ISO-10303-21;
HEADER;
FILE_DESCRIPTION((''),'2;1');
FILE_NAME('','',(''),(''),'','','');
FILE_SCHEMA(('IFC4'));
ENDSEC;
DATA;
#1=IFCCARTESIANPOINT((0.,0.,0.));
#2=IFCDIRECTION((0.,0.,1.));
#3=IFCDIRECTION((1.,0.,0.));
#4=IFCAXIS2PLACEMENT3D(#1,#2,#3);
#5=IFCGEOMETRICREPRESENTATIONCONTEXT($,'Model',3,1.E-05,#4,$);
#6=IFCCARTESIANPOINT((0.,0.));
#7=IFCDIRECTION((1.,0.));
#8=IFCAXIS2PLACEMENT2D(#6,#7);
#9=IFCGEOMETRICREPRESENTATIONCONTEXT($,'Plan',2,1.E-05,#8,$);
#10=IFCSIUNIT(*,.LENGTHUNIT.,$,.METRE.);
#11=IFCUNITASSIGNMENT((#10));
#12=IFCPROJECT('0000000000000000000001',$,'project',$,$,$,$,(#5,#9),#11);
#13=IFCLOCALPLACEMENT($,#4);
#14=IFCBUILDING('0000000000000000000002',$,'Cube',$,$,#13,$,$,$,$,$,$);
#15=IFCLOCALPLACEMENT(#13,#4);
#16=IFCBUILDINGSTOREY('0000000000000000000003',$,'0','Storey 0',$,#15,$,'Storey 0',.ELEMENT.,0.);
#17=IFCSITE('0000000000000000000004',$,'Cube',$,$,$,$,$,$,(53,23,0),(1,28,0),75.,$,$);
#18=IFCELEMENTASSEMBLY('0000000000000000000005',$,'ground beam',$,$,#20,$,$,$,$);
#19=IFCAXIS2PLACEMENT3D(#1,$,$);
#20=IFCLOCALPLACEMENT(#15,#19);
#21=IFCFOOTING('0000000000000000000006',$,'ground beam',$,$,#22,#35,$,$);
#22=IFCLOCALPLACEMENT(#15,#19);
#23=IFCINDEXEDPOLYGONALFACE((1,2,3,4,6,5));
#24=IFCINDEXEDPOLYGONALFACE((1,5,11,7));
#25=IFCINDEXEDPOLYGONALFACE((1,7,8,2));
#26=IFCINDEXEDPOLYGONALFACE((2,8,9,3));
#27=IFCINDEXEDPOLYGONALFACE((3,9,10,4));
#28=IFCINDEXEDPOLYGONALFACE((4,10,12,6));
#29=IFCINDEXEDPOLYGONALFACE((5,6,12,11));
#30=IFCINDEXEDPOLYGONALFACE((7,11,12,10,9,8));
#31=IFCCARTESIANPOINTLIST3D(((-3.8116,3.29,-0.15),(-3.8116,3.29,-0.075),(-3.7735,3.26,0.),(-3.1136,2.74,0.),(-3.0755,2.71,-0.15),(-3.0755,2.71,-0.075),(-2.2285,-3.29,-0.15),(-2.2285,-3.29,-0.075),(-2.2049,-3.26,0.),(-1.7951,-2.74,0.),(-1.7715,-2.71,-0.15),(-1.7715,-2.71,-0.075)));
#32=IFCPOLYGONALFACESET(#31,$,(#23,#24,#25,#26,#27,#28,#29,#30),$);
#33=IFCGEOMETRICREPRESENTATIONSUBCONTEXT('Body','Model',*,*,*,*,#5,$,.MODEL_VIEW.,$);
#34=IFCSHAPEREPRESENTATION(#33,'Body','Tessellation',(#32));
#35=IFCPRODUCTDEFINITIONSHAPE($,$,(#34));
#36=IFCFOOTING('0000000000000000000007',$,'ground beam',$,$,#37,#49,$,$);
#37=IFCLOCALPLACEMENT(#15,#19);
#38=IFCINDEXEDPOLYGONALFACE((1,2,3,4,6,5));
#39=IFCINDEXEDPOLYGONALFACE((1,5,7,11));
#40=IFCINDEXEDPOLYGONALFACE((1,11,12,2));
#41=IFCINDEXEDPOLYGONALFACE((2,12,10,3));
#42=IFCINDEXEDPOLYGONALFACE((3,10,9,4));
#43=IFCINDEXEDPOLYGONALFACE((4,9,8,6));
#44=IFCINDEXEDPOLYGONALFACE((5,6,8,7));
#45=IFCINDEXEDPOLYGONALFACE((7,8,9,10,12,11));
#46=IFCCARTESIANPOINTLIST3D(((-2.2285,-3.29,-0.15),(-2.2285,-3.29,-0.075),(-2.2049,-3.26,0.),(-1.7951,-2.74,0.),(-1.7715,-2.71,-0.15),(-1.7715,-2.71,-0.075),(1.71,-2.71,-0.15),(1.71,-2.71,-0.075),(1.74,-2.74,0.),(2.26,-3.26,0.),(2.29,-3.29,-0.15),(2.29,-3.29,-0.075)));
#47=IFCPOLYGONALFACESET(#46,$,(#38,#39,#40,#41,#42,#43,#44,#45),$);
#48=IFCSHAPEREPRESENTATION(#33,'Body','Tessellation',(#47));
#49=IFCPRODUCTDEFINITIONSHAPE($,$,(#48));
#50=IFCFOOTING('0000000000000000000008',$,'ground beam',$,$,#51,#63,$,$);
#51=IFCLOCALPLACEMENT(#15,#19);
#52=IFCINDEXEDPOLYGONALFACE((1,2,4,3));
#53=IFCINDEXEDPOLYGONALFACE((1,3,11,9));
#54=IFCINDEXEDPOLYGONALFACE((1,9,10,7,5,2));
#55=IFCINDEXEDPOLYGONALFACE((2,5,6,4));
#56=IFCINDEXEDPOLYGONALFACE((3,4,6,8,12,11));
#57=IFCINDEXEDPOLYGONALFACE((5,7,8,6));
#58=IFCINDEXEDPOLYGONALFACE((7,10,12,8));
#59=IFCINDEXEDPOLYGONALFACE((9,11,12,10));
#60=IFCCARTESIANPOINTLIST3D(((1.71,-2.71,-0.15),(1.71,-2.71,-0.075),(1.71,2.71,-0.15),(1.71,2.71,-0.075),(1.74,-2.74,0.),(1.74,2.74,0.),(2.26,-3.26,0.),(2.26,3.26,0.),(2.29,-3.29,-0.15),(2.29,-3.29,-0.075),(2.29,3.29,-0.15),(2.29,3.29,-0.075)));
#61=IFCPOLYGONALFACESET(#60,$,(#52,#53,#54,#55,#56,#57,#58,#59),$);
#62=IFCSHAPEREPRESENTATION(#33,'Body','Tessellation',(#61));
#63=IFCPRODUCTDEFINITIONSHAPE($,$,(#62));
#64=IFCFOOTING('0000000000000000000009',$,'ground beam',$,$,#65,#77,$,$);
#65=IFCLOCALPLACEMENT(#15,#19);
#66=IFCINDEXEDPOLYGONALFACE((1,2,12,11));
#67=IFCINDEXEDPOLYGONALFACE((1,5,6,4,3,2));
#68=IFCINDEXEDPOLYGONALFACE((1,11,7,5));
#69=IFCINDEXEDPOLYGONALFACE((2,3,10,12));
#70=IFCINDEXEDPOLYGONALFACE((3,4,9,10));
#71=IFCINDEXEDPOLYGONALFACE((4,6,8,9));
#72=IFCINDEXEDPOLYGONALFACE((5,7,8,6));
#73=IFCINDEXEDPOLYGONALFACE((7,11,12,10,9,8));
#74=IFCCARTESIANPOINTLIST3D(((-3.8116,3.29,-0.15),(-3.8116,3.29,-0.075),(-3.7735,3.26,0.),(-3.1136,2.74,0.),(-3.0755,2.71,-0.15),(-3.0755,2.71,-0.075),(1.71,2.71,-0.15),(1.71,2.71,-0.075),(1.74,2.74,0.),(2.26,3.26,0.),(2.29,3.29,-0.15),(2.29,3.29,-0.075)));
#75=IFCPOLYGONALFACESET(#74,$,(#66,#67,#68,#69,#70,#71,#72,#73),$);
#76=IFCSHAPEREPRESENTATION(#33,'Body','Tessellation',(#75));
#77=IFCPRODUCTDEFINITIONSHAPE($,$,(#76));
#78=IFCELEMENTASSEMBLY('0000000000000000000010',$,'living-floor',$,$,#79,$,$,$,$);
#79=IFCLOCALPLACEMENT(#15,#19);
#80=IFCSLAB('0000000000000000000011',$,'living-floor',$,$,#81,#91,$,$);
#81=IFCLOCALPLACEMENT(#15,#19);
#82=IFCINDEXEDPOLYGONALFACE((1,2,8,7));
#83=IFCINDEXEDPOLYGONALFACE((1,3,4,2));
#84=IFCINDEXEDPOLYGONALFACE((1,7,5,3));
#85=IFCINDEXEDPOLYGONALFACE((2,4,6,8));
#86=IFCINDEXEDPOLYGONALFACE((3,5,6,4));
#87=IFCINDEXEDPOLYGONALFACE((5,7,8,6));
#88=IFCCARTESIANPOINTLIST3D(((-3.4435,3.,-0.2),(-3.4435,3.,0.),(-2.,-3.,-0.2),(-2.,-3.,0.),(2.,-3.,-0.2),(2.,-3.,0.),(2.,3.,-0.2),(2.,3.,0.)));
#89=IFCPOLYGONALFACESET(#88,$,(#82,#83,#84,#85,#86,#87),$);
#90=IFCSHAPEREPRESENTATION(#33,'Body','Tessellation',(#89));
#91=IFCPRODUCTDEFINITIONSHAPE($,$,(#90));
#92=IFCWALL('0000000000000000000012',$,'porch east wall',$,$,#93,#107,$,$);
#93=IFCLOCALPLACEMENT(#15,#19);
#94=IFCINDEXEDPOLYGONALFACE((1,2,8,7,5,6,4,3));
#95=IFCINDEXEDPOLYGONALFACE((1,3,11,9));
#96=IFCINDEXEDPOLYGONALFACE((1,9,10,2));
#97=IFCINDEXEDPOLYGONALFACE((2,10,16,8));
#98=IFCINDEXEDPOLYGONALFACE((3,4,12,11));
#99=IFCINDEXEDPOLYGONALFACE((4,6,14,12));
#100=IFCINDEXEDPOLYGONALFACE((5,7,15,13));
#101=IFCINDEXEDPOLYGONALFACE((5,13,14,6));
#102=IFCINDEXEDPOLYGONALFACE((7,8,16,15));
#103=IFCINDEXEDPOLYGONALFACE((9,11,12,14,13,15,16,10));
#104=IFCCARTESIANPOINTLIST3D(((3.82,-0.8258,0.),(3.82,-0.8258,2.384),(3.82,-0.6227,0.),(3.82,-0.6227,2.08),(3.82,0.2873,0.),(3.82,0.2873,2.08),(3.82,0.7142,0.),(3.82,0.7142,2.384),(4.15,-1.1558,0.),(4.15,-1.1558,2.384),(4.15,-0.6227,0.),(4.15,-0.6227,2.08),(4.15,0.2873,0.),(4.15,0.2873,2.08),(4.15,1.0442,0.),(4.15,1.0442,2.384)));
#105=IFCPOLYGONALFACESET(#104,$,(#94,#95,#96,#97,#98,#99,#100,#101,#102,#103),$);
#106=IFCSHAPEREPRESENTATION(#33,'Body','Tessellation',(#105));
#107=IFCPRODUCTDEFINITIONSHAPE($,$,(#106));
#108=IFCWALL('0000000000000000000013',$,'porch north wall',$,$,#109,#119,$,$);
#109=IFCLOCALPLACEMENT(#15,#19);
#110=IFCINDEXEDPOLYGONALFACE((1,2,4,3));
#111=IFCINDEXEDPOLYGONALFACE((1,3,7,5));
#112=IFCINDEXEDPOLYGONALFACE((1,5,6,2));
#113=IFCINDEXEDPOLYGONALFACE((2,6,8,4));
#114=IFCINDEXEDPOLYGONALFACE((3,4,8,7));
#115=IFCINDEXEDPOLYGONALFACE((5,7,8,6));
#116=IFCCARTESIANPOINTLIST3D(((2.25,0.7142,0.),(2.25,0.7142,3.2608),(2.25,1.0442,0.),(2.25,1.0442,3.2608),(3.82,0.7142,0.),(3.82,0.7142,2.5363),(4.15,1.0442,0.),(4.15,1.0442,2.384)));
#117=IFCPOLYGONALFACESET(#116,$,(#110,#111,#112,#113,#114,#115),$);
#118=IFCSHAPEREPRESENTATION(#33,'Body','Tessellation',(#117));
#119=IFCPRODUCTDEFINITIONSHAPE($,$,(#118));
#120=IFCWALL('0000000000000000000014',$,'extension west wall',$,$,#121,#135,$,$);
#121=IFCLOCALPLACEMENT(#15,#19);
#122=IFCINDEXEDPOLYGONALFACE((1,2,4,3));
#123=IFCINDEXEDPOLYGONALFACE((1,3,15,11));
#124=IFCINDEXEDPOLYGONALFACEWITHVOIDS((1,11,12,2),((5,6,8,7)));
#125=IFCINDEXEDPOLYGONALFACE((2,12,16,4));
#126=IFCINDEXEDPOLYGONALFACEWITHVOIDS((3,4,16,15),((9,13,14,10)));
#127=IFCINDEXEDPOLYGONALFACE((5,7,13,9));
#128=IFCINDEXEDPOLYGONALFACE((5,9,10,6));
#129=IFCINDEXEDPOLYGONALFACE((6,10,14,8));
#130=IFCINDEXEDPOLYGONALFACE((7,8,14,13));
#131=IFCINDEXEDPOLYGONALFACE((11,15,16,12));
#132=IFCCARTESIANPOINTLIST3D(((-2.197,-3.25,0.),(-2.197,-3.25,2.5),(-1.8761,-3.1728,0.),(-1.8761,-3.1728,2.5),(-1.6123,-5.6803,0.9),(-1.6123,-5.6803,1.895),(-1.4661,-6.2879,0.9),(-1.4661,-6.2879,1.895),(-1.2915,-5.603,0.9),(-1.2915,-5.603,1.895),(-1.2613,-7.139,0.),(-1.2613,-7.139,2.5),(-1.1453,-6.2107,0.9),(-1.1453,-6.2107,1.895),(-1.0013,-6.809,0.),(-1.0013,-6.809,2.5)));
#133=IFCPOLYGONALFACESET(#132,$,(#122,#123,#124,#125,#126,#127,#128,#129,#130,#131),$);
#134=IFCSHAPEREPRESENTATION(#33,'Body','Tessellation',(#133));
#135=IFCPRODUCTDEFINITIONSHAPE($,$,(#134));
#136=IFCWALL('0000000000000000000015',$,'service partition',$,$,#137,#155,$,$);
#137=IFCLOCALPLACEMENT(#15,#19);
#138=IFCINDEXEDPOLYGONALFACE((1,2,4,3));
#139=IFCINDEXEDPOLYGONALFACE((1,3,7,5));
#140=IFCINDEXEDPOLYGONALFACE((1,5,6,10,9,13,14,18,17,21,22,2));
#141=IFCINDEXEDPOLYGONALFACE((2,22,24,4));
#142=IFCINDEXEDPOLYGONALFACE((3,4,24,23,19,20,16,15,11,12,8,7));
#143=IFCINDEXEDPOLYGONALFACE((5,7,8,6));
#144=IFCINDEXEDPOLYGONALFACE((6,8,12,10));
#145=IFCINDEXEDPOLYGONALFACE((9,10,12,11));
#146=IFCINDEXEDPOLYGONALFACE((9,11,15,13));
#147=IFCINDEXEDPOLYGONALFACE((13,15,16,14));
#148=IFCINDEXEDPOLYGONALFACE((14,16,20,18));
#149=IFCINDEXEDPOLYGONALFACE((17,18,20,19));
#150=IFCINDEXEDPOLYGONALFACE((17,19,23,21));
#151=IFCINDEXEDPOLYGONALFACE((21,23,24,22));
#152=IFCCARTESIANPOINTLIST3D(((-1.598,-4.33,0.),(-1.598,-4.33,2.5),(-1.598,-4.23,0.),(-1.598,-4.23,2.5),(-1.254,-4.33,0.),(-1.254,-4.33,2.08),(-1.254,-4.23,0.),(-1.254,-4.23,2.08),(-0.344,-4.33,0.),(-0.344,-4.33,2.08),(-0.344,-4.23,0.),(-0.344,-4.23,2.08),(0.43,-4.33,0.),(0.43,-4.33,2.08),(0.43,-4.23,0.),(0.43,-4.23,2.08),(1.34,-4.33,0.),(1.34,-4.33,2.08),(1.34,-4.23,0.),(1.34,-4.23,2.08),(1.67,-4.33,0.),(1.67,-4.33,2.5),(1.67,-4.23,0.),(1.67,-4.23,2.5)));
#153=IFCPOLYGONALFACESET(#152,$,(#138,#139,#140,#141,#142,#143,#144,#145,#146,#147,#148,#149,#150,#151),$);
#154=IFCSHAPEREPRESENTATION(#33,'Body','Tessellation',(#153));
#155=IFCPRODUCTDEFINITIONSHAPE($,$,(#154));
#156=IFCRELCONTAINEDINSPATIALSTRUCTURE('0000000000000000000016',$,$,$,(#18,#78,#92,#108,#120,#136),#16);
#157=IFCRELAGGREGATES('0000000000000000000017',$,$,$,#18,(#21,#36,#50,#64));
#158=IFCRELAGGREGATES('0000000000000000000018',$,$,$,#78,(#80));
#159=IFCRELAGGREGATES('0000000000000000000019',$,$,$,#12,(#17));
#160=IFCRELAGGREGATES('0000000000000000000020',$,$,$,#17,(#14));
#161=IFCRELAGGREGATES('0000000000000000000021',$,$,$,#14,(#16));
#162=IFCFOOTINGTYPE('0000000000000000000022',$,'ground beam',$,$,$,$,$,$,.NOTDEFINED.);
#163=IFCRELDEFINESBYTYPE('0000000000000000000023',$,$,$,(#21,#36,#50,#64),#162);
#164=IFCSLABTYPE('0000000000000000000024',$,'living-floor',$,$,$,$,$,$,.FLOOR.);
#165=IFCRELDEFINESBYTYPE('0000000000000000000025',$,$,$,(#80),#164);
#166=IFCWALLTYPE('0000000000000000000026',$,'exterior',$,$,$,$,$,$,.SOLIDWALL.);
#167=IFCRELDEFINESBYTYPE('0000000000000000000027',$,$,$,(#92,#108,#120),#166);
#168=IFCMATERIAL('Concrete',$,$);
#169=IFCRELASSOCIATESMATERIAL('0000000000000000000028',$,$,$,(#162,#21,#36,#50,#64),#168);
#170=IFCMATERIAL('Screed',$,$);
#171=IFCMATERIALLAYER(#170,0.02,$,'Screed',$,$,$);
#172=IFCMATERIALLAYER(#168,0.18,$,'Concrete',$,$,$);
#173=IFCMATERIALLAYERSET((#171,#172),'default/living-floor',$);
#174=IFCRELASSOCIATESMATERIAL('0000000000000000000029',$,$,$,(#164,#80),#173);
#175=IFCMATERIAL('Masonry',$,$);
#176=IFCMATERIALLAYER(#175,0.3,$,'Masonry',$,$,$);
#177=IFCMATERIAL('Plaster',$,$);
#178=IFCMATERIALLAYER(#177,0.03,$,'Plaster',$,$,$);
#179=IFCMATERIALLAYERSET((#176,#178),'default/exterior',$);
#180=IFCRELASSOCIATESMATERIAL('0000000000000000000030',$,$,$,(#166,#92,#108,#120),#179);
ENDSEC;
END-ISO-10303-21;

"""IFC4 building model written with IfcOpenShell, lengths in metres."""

from ifc_helpers import new_model, si_unit, frame, origin, origin_with_axes, origin_2d_with_axis, place, context, subcontext, project, spatial, polyline, line, indexed_curve, outline, extrude, clip, halfspace, source, transform, mapped, material, layer, layer_set, layer_usage, material_profile, profile_set, profile_usage, type_object, element, aggregate, save


model = new_model("IFC4")

# Units and contexts
model_context = context("Model", 3, precision=1e-05, world=origin_with_axes())
plan_context = context("Plan", 2, precision=1e-05, world=origin_2d_with_axis())
body_context = subcontext(model_context, "Body", "Model", "MODEL_VIEW")
ifc_project = project(units=[si_unit("LENGTHUNIT", "METRE")], contexts=[model_context, plan_context])

# Site, building, storey
site = spatial("IfcSite", under=ifc_project, Name="Cube", RefLatitude=(53, 23, 0), RefLongitude=(1, 28, 0), RefElevation=75.0)
building_placement = place(None, origin_with_axes())
building = spatial("IfcBuilding", under=site, at=building_placement, Name="Cube")
storey_placement = place(building_placement, origin_with_axes())
storey = spatial("IfcBuildingStorey", under=building, at=storey_placement, Name="0", Description="Storey 0", LongName="Storey 0", CompositionType="ELEMENT", Elevation=0.0)

# Element assembly, footings
assembly_1_placement = place(storey_placement, origin_with_axes())
assembly_1 = element("IfcElementAssembly", 1, at=assembly_1_placement, inside=storey, Name="ground beam")
ifc_material_1 = material(Name="Concrete")
ifc_material_profile = material_profile(ifc_material_1, outline(polyline([(-0.26, 0.0), (-0.29, -0.075), (-0.29, -0.15), (0.29, -0.15), (0.29, -0.075), (0.26, 0.0), (-0.26, 0.0)])))
ifc_profile_set = profile_set([ifc_material_profile])
ifc_profile_usage_1 = profile_usage(ifc_profile_set)
footing_type = type_object("IfcFootingType", Name="ground beam", PredefinedType="NOTDEFINED", material=ifc_profile_set)
footing_1_placement = place(assembly_1_placement, frame((-1.7661, -3.9723, 0.0), z_axis=(-0.233915, 0.972257, 0.0), x_axis=(-0.972257, -0.233915, 0.0)))
footing_1 = element("IfcFooting", 2, at=footing_1_placement, type_object=footing_type, material=ifc_profile_usage_1, Name="ground beam", context=body_context, shape_type="Clipping", body=[
    clip(clip(extrude(outline(polyline([(-0.26, 0.0), (-0.29, -0.075), (-0.29, -0.15), (0.29, -0.15), (0.29, -0.075), (0.26, 0.0), (-0.26, 0.0)])), origin_with_axes(), (0.0, 0.0, 1.0), 8.1712), halfspace(frame((0.0, 0.0, 1.0), z_axis=(-0.618904, 0.0, -0.785467), x_axis=(0.0, 1.0, 0.0)), False)), halfspace(frame((0.0, 0.0, 7.1712), z_axis=(-0.785467, 0.0, 0.618904), x_axis=(0.0, 1.0, 0.0)), False)),
])
ifc_profile_usage_2 = profile_usage(ifc_profile_set)
footing_2_placement = place(assembly_1_placement, frame((3.0, -3.0, 0.0), z_axis=(-1.0, 0.0, 0.0), x_axis=(0.0, -1.0, 0.0)))
footing_2 = element("IfcFooting", 3, at=footing_2_placement, type_object=footing_type, material=ifc_profile_usage_2, Name="ground beam", context=body_context, shape_type="Clipping", body=[
    clip(clip(extrude(outline(polyline([(-0.26, 0.0), (-0.29, -0.075), (-0.29, -0.15), (0.29, -0.15), (0.29, -0.075), (0.26, 0.0), (-0.26, 0.0)])), origin_with_axes(), (0.0, 0.0, 1.0), 6.0), halfspace(frame((0.0, 0.0, 1.0), z_axis=(-0.707107, 0.0, -0.707107), x_axis=(0.0, 1.0, 0.0)), False)), halfspace(frame((0.0, 0.0, 5.0), z_axis=(-0.618904, 0.0, 0.785467), x_axis=(0.0, 1.0, 0.0)), False)),
])
ifc_profile_usage_3 = profile_usage(ifc_profile_set)
footing_3_placement = place(assembly_1_placement, frame((2.0, 4.0, 0.0), z_axis=(0.0, -1.0, 0.0), x_axis=(1.0, 0.0, 0.0)))
footing_3 = element("IfcFooting", 4, at=footing_3_placement, type_object=footing_type, material=ifc_profile_usage_3, Name="ground beam", context=body_context, shape_type="Clipping", body=[
    clip(clip(extrude(outline(polyline([(-0.26, 0.0), (-0.29, -0.075), (-0.29, -0.15), (0.29, -0.15), (0.29, -0.075), (0.26, 0.0), (-0.26, 0.0)])), origin_with_axes(), (0.0, 0.0, 1.0), 8.0), halfspace(frame((0.0, 0.0, 1.0), z_axis=(-0.707107, 0.0, -0.707107), x_axis=(0.0, 1.0, 0.0)), False)), halfspace(frame((0.0, 0.0, 7.0), z_axis=(-0.707107, 0.0, 0.707107), x_axis=(0.0, 1.0, 0.0)), False)),
])
ifc_profile_usage_4 = profile_usage(ifc_profile_set)
footing_4_placement = place(assembly_1_placement, frame((-4.4435, 3.0, 0.0), z_axis=(1.0, 0.0, 0.0), x_axis=(0.0, 1.0, 0.0)))
footing_4 = element("IfcFooting", 5, at=footing_4_placement, type_object=footing_type, material=ifc_profile_usage_4, Name="ground beam", context=body_context, shape_type="Clipping", body=[
    clip(clip(extrude(outline(polyline([(-0.26, 0.0), (-0.29, -0.075), (-0.29, -0.15), (0.29, -0.15), (0.29, -0.075), (0.26, 0.0), (-0.26, 0.0)])), origin_with_axes(), (0.0, 0.0, 1.0), 7.4435), halfspace(frame((0.0, 0.0, 1.0), z_axis=(-0.785467, 0.0, -0.618904), x_axis=(0.0, 1.0, 0.0)), False)), halfspace(frame((0.0, 0.0, 6.4435), z_axis=(-0.707107, 0.0, 0.707107), x_axis=(0.0, 1.0, 0.0)), False)),
])
aggregate(assembly_1, [footing_1, footing_2, footing_3, footing_4])

# Element assembly, slab
assembly_2_placement = place(storey_placement, origin_with_axes())
assembly_2 = element("IfcElementAssembly", 6, at=assembly_2_placement, inside=storey, Name="living-floor")
ifc_material_2 = material(Name="Screed")
ifc_layer_1 = layer(ifc_material_2, 0.02, Name="Screed")
ifc_layer_2 = layer(ifc_material_1, 0.18, Name="Concrete")
ifc_layer_set_1 = layer_set([ifc_layer_1, ifc_layer_2], Name="default/living-floor")
ifc_layer_usage_1 = layer_usage(ifc_layer_set_1, "AXIS3", "POSITIVE", 0.0)
slab_type = type_object("IfcSlabType", Name="living-floor", PredefinedType="FLOOR", material=ifc_layer_set_1)
slab_placement = place(assembly_2_placement, frame((2.0, 3.0, -0.2), z_axis=(0.0, 0.0, -1.0), x_axis=(0.0, 1.0, 0.0)))
slab = element("IfcSlab", 7, at=slab_placement, type_object=slab_type, material=ifc_layer_usage_1, Name="living-floor", context=body_context, shape_type="SweptSolid", body=[
    extrude(outline(polyline([(0.0, 0.0), (-6.0, 0.0), (-6.0, -4.0), (0.0, -5.4435), (0.0, 0.0)])), origin(), (0.0, 0.0, -1.0), 0.2),
])
aggregate(assembly_2, [slab])

# Wall, opening
ifc_material_3 = material(Name="Masonry")
ifc_layer_3 = layer(ifc_material_3, 0.3, Name="Masonry")
ifc_material_4 = material(Name="Plaster")
ifc_layer_4 = layer(ifc_material_4, 0.03, Name="Plaster")
ifc_layer_set_2 = layer_set([ifc_layer_3, ifc_layer_4], Name="default/exterior")
wall_type = type_object("IfcWallType", Name="exterior", PredefinedType="SOLIDWALL", material=ifc_layer_set_2)
ifc_layer_usage_2 = layer_usage(ifc_layer_set_2, "AXIS2", "POSITIVE", 0.0)
wall_1_placement = place(storey_placement, frame((4.15, -1.1558, 0.0), z_axis=(0.0, 0.0, 1.0), x_axis=(0.0, 1.0, 0.0)))
wall_1 = element("IfcWall", 8, at=wall_1_placement, inside=storey, type_object=wall_type, material=ifc_layer_usage_2, Name="porch east wall", context=body_context, shape_type="SweptSolid", body=[
    extrude(outline(indexed_curve([(0.0, 0.0), (0.33, 0.33), (1.87, 0.33), (2.2, 0.0)], segments=[line(1, 2, 3, 4, 1)])), origin_with_axes(), (0.0, 0.0, 1.0), 2.384),
])
shared_shape = source(origin_with_axes(), body_context, "Body", "SweptSolid", [
    extrude(outline(indexed_curve([(0.0, 0.0), (0.91, 0.0), (0.91, 2.08), (0.0, 2.08)], segments=[line(1, 2, 3, 4, 1)])), frame((0.0, -0.6, 0.0), z_axis=(0.0, -1.0, 0.0), x_axis=(1.0, 0.0, 0.0)), (0.0, 0.0, -1.0), 1.2),
])
opening_1_placement = place(wall_1_placement, frame((0.5331, 0.0, 0.0), z_axis=(0.0, 0.0, 1.0), x_axis=(1.0, 0.0, 0.0)))
element("IfcOpeningElement", 9, at=opening_1_placement, cuts=wall_1, PredefinedType="OPENING", context=body_context, shape_type="MappedRepresentation", body=[
    mapped(shared_shape, transform((0.0, 0.0, 0.0), x_axis=(1.0, 0.0, 0.0), y_axis=(0.0, 1.0, 0.0), z_axis=(0.0, 0.0, 1.0), scale=1.0)),
])

# Wall
ifc_layer_usage_3 = layer_usage(ifc_layer_set_2, "AXIS2", "POSITIVE", 0.0)
wall_2_placement = place(storey_placement, frame((4.15, 1.0442, 0.0), z_axis=(0.0, 0.0, 1.0), x_axis=(-1.0, 0.0, 0.0)))
element("IfcWall", 10, at=wall_2_placement, inside=storey, type_object=wall_type, material=ifc_layer_usage_3, Name="porch north wall", context=body_context, shape_type="Clipping", body=[
    clip(extrude(outline(indexed_curve([(0.0, 0.0), (1.9, 0.0), (1.9, 0.33), (0.33, 0.33)], segments=[line(1, 2, 3, 4, 1)])), origin_with_axes(), (0.0, 0.0, 1.0), 3.5), halfspace(frame((0.0, 0.0, 2.384), z_axis=(-0.419, 0.0, 0.908), x_axis=(0.0, 1.0, 0.0)), False)),
])

# Wall, opening
ifc_layer_usage_4 = layer_usage(ifc_layer_set_2, "AXIS2", "POSITIVE", 0.0)
wall_3_placement = place(storey_placement, frame((-2.197, -3.25, 0.0), z_axis=(0.0, 0.0, 1.0), x_axis=(0.233916, -0.972257, 0.0)))
wall_3 = element("IfcWall", 11, at=wall_3_placement, inside=storey, type_object=wall_type, material=ifc_layer_usage_4, Name="extension west wall", context=body_context, shape_type="SweptSolid", body=[
    extrude(outline(indexed_curve([(0.0, 0.0), (0.0, 0.33), (3.7399, 0.33), (4.0, 0.0)], segments=[line(1, 2, 3, 4, 1)])), origin_with_axes(), (0.0, 0.0, 1.0), 2.5),
])
opening_2_placement = place(wall_3_placement, frame((2.4996, -0.0501, 0.9), z_axis=(0.0, 0.0, 1.0), x_axis=(1.0, 0.000142, 0.0)))
element("IfcOpeningElement", 12, at=opening_2_placement, cuts=wall_3, PredefinedType="OPENING", context=body_context, shape_type="SweptSolid", body=[
    extrude(outline(indexed_curve([(0.0, 0.0), (0.0, 0.43), (0.625, 0.43), (0.625, 0.0), (0.0, 0.0)], self_intersect=False)), origin_with_axes(), (0.0, 0.0, 1.0), 0.995),
])

# Wall, openings
wall_4_placement = place(storey_placement, frame((-1.598, -4.33, 0.0), z_axis=(0.0, 0.0, 1.0), x_axis=(1.0, 0.0, 0.0)))
wall_4 = element("IfcWall", 13, at=wall_4_placement, inside=storey, Name="service partition", context=body_context, shape_type="SweptSolid", body=[
    extrude(outline(indexed_curve([(0.0, 0.0), (0.0, 0.1), (3.268, 0.1), (3.268, 0.0), (0.0, 0.0)], self_intersect=False)), origin_with_axes(), (0.0, 0.0, 1.0), 2.5),
])
opening_3_placement = place(wall_4_placement, frame((0.344, -0.05, 0.0), z_axis=(0.0, 0.0, 1.0), x_axis=(1.0, 0.0, 0.0)))
element("IfcOpeningElement", 14, at=opening_3_placement, cuts=wall_4, context=body_context, shape_type="SweptSolid", body=[
    extrude(outline(indexed_curve([(0.0, 0.0), (0.0, 0.3), (0.91, 0.3), (0.91, 0.0), (0.0, 0.0)], self_intersect=False)), origin_with_axes(), (0.0, 0.0, 1.0), 2.08),
])
opening_4_placement = place(wall_4_placement, frame((2.028, -0.05, 0.0), z_axis=(0.0, 0.0, 1.0), x_axis=(1.0, 0.0, 0.0)))
element("IfcOpeningElement", 15, at=opening_4_placement, cuts=wall_4, context=body_context, shape_type="SweptSolid", body=[
    extrude(outline(indexed_curve([(0.0, 0.0), (0.0, 0.3), (0.91, 0.3), (0.91, 0.0), (0.0, 0.0)], self_intersect=False)), origin_with_axes(), (0.0, 0.0, 1.0), 2.08),
])

save(model, "model.ifc")
